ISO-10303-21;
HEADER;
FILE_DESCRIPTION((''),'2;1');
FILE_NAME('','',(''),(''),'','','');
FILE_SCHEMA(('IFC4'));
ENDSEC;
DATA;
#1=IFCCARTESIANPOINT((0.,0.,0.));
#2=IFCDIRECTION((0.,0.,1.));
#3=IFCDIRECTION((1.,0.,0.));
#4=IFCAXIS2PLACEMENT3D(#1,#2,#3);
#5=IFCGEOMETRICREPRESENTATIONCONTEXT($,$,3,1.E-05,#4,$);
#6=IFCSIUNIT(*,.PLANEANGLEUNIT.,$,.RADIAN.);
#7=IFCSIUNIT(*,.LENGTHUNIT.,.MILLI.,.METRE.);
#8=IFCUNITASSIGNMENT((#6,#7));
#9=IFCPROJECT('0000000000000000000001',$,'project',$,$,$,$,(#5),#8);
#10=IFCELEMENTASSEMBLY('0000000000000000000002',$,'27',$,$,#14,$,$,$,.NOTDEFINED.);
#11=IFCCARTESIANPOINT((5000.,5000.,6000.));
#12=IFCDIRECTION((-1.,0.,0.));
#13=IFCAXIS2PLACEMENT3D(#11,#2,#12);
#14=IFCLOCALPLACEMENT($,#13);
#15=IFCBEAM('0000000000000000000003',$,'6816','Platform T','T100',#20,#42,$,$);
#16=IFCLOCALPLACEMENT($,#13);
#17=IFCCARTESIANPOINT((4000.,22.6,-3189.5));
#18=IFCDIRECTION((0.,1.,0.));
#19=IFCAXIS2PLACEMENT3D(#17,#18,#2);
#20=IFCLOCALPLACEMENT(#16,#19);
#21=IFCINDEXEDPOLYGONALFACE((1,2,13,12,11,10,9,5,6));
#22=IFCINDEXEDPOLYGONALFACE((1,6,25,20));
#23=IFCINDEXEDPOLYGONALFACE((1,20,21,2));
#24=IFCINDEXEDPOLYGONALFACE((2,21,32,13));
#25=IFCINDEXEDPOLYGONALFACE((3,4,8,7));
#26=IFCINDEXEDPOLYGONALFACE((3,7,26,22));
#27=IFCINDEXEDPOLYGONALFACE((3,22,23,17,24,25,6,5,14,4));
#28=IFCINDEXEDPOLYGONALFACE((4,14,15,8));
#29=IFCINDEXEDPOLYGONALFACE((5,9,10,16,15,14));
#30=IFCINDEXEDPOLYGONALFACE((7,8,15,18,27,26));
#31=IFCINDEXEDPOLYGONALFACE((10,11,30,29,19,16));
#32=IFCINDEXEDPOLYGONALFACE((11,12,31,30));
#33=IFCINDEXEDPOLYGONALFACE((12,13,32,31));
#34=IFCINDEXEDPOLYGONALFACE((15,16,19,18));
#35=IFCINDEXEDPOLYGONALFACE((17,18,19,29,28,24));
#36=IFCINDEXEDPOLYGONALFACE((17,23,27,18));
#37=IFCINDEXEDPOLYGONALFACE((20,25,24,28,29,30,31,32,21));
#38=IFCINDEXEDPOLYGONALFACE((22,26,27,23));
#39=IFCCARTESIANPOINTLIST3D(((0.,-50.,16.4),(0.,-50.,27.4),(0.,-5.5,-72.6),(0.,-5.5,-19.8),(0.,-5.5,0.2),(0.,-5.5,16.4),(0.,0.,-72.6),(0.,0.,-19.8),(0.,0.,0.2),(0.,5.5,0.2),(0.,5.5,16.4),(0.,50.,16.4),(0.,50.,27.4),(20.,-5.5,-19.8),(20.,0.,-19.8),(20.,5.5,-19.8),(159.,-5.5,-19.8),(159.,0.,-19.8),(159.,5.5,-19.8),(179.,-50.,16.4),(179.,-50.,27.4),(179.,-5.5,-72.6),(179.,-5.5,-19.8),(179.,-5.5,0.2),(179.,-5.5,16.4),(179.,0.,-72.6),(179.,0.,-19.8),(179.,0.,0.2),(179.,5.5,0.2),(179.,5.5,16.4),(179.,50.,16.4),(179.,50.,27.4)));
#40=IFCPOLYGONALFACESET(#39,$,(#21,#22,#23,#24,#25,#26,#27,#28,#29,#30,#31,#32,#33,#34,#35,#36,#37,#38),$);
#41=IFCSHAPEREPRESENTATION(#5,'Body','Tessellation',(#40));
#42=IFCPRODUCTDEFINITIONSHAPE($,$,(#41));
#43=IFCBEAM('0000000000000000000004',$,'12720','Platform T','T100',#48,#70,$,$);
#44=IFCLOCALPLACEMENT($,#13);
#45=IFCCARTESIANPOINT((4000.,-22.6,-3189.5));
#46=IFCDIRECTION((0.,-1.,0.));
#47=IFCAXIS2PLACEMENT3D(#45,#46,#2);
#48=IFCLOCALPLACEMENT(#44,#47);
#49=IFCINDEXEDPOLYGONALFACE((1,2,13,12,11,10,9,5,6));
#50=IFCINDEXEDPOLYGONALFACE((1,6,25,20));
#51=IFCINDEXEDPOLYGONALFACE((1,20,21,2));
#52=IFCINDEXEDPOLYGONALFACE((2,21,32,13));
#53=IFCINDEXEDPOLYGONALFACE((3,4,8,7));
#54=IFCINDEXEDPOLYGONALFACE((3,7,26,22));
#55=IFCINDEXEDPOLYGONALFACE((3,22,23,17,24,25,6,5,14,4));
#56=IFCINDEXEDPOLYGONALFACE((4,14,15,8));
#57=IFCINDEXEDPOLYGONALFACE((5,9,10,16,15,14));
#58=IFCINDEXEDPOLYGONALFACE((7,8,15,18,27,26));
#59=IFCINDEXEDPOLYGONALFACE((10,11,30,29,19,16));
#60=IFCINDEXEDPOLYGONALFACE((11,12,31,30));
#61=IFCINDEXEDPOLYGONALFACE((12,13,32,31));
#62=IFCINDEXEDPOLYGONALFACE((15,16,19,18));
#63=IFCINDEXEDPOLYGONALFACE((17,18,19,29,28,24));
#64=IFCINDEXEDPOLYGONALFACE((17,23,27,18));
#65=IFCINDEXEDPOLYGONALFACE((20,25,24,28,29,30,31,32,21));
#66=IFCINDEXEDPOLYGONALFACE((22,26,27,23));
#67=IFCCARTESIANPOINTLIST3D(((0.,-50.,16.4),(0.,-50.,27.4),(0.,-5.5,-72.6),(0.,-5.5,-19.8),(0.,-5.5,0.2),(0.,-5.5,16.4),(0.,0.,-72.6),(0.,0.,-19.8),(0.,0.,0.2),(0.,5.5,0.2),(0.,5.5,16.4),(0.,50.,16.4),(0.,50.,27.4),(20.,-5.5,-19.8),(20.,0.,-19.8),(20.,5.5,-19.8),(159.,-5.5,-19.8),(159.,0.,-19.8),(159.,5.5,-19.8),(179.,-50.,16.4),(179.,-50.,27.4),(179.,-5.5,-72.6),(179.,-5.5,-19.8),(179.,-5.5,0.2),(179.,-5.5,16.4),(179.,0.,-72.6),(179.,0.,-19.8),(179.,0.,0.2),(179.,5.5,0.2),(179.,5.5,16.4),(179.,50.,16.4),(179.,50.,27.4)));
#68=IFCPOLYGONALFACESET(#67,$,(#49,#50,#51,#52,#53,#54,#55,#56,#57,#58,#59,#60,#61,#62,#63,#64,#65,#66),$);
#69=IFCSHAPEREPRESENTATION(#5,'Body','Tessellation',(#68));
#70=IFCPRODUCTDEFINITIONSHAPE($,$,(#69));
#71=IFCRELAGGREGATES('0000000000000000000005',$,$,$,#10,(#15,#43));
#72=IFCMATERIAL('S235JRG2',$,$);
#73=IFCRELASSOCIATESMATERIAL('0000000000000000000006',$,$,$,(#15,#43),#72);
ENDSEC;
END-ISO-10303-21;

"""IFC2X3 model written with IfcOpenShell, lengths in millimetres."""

from ifc_helpers import new_model, si_unit, point, frame, origin_with_axes, place, context, project, polyline, line_curve, trimmed, segment, composite_curve, outline, extrude, material, element, aggregate, save


model = new_model("IFC2X3")

# Units and contexts
context_of_model = context(None, 3, precision=1e-05, world=origin_with_axes())
ifc_project = project(units=[si_unit("PLANEANGLEUNIT", "RADIAN"), si_unit("LENGTHUNIT", "METRE", prefix="MILLI")], contexts=[context_of_model])

# Element assembly, beams, openings
assembly_1_placement = place(None, frame((5000.0, 5000.0, 6000.0), z_axis=(0.0, 0.0, 1.0), x_axis=(-1.0, 0.0, 0.0)))
assembly_1 = element("IfcElementAssembly", 1, at=assembly_1_placement, Name="27", PredefinedType="NOTDEFINED")
ifc_material = material(Name="S235JRG2")
placement_1 = place(None, frame((5000.0, 5000.0, 6000.0), z_axis=(0.0, 0.0, 1.0), x_axis=(-1.0, 0.0, 0.0)))
beam_1_placement = place(placement_1, frame((4000.0, 22.6, -3189.5), z_axis=(0.0, 1.0, 0.0), x_axis=(0.0, 0.0, 1.0)))
beam_1 = element("IfcBeam", 2, at=beam_1_placement, material=ifc_material, Name="6816", Description="Platform T", ObjectType="T100", context=context_of_model, shape_type="SweptSolid", body=[
    extrude(outline(polyline([(5.5, -72.6), (5.5, 16.4), (50.0, 16.4), (50.0, 27.4), (-50.0, 27.4), (-50.0, 16.4), (-5.5, 16.4), (-5.5, -72.6), (5.5, -72.6), (5.5, -72.6)])), frame((0.0, 0.0, 0.0), z_axis=(1.0, 0.0, 0.0), x_axis=(0.0, 1.0, 0.0)), (0.0, 0.0, 1.0), 179.0),
])
opening_1_placement = place(beam_1_placement, frame((179.0, 0.0, -72.6), z_axis=(0.0, 1.0, 0.0), x_axis=(0.0, 0.0, 1.0)))
element("IfcOpeningElement", 3, at=opening_1_placement, cuts=beam_1, ObjectType="Recess", context=context_of_model, shape_type="SweptSolid", body=[
    extrude(outline(composite_curve([segment(trimmed(line_curve((0.0, 0.0), (0.0, -1.0, 0.0), 179.0), [point((0.0, 0.0))], [point((0.0, -179.0))], True, "CARTESIAN"), True, "CONTINUOUS"), segment(trimmed(line_curve((0.0, -179.0), (1.0, 0.0, 0.0), 52.8), [point((0.0, -179.0))], [point((52.8, -179.0))], True, "CARTESIAN"), True, "CONTINUOUS"), segment(trimmed(line_curve((52.8, -179.0), (0.0, 1.0, 0.0), 179.0), [point((52.8, -179.0))], [point((52.8, 0.0))], True, "CARTESIAN"), True, "CONTINUOUS"), segment(trimmed(line_curve((52.8, 0.0), (-1.0, 0.0, 0.0), 52.8), [point((52.8, 0.0))], [point((0.0, 0.0))], True, "CARTESIAN"), True, "CONTINUOUS")], self_intersect=False)), origin_with_axes(), (0.0, 0.0, 1.0), 100.0),
])
opening_2_placement = place(beam_1_placement, frame((179.0, 0.0, -19.8), z_axis=(0.0, 1.0, 0.0), x_axis=(0.0, 0.0, 1.0)))
element("IfcOpeningElement", 4, at=opening_2_placement, cuts=beam_1, context=context_of_model, shape_type="SweptSolid", body=[
    extrude(outline(composite_curve([segment(trimmed(line_curve((0.0, 0.0), (1.0, 0.0, 0.0), 20.0), [point((0.0, 0.0))], [point((20.0, 0.0))], True, "CARTESIAN"), True, "CONTINUOUS"), segment(trimmed(line_curve((20.0, 0.0), (-0.707107, -0.707107, 0.0), 28.284271), [point((20.0, 0.0))], [point((0.0, -20.0))], True, "CARTESIAN"), True, "CONTINUOUS"), segment(trimmed(line_curve((0.0, -20.0), (0.0, 1.0, 0.0), 20.0), [point((0.0, -20.0))], [point((0.0, 0.0))], True, "CARTESIAN"), True, "CONTINUOUS")], self_intersect=False)), origin_with_axes(), (0.0, 0.0, 1.0), 100.0),
])
opening_3_placement = place(beam_1_placement, frame((179.0, 0.0, -19.8), z_axis=(0.0, -1.0, 0.0), x_axis=(0.0, 0.0, -1.0)))
element("IfcOpeningElement", 5, at=opening_3_placement, cuts=beam_1, context=context_of_model, shape_type="SweptSolid", body=[
    extrude(outline(composite_curve([segment(trimmed(line_curve((0.0, 0.0), (-1.0, 0.0, 0.0), 20.0), [point((0.0, 0.0))], [point((-20.0, 0.0))], True, "CARTESIAN"), True, "CONTINUOUS"), segment(trimmed(line_curve((-20.0, 0.0), (0.707107, -0.707107, 0.0), 28.284271), [point((-20.0, 0.0))], [point((0.0, -20.0))], True, "CARTESIAN"), True, "CONTINUOUS"), segment(trimmed(line_curve((0.0, -20.0), (0.0, 1.0, 0.0), 20.0), [point((0.0, -20.0))], [point((0.0, 0.0))], True, "CARTESIAN"), True, "CONTINUOUS")], self_intersect=False)), origin_with_axes(), (0.0, 0.0, 1.0), 100.0),
])
opening_4_placement = place(beam_1_placement, frame((0.0, 0.0, -19.8), z_axis=(0.0, -1.0, 0.0), x_axis=(0.0, 0.0, -1.0)))
element("IfcOpeningElement", 6, at=opening_4_placement, cuts=beam_1, context=context_of_model, shape_type="SweptSolid", body=[
    extrude(outline(composite_curve([segment(trimmed(line_curve((0.0, 0.0), (-1.0, 0.0, 0.0), 20.0), [point((0.0, 0.0))], [point((-20.0, 0.0))], True, "CARTESIAN"), True, "CONTINUOUS"), segment(trimmed(line_curve((-20.0, 0.0), (0.707107, 0.707107, 0.0), 28.284271), [point((-20.0, 0.0))], [point((0.0, 20.0))], True, "CARTESIAN"), True, "CONTINUOUS"), segment(trimmed(line_curve((0.0, 20.0), (0.0, -1.0, 0.0), 20.0), [point((0.0, 20.0))], [point((0.0, 0.0))], True, "CARTESIAN"), True, "CONTINUOUS")], self_intersect=False)), origin_with_axes(), (0.0, 0.0, 1.0), 100.0),
])
opening_5_placement = place(beam_1_placement, frame((0.0, 0.0, -19.8), z_axis=(0.0, 1.0, 0.0), x_axis=(0.0, 0.0, 1.0)))
element("IfcOpeningElement", 7, at=opening_5_placement, cuts=beam_1, context=context_of_model, shape_type="SweptSolid", body=[
    extrude(outline(composite_curve([segment(trimmed(line_curve((0.0, 0.0), (1.0, 0.0, 0.0), 20.0), [point((0.0, 0.0))], [point((20.0, 0.0))], True, "CARTESIAN"), True, "CONTINUOUS"), segment(trimmed(line_curve((20.0, 0.0), (-0.707107, 0.707107, 0.0), 28.284271), [point((20.0, 0.0))], [point((0.0, 20.0))], True, "CARTESIAN"), True, "CONTINUOUS"), segment(trimmed(line_curve((0.0, 20.0), (0.0, -1.0, 0.0), 20.0), [point((0.0, 20.0))], [point((0.0, 0.0))], True, "CARTESIAN"), True, "CONTINUOUS")], self_intersect=False)), origin_with_axes(), (0.0, 0.0, 1.0), 100.0),
])
placement_2 = place(None, frame((5000.0, 5000.0, 6000.0), z_axis=(0.0, 0.0, 1.0), x_axis=(-1.0, 0.0, 0.0)))
beam_2_placement = place(placement_2, frame((4000.0, -22.6, -3189.5), z_axis=(0.0, -1.0, 0.0), x_axis=(0.0, 0.0, 1.0)))
beam_2 = element("IfcBeam", 8, at=beam_2_placement, material=ifc_material, Name="12720", Description="Platform T", ObjectType="T100", context=context_of_model, shape_type="SweptSolid", body=[
    extrude(outline(polyline([(5.5, -72.6), (5.5, 16.4), (50.0, 16.4), (50.0, 27.4), (-50.0, 27.4), (-50.0, 16.4), (-5.5, 16.4), (-5.5, -72.6), (5.5, -72.6), (5.5, -72.6)])), frame((0.0, 0.0, 0.0), z_axis=(1.0, 0.0, 0.0), x_axis=(0.0, 1.0, 0.0)), (0.0, 0.0, 1.0), 179.0),
])
opening_6_placement = place(beam_2_placement, frame((179.0, 0.0, -72.6), z_axis=(0.0, 1.0, 0.0), x_axis=(0.0, 0.0, 1.0)))
element("IfcOpeningElement", 9, at=opening_6_placement, cuts=beam_2, ObjectType="Recess", context=context_of_model, shape_type="SweptSolid", body=[
    extrude(outline(composite_curve([segment(trimmed(line_curve((0.0, 0.0), (0.0, -1.0, 0.0), 179.0), [point((0.0, 0.0))], [point((0.0, -179.0))], True, "CARTESIAN"), True, "CONTINUOUS"), segment(trimmed(line_curve((0.0, -179.0), (1.0, 0.0, 0.0), 52.8), [point((0.0, -179.0))], [point((52.8, -179.0))], True, "CARTESIAN"), True, "CONTINUOUS"), segment(trimmed(line_curve((52.8, -179.0), (0.0, 1.0, 0.0), 179.0), [point((52.8, -179.0))], [point((52.8, 0.0))], True, "CARTESIAN"), True, "CONTINUOUS"), segment(trimmed(line_curve((52.8, 0.0), (-1.0, 0.0, 0.0), 52.8), [point((52.8, 0.0))], [point((0.0, 0.0))], True, "CARTESIAN"), True, "CONTINUOUS")], self_intersect=False)), origin_with_axes(), (0.0, 0.0, 1.0), 100.0),
])
opening_7_placement = place(beam_2_placement, frame((179.0, 0.0, -19.8), z_axis=(0.0, 1.0, 0.0), x_axis=(0.0, 0.0, 1.0)))
element("IfcOpeningElement", 10, at=opening_7_placement, cuts=beam_2, context=context_of_model, shape_type="SweptSolid", body=[
    extrude(outline(composite_curve([segment(trimmed(line_curve((0.0, 0.0), (1.0, 0.0, 0.0), 20.0), [point((0.0, 0.0))], [point((20.0, 0.0))], True, "CARTESIAN"), True, "CONTINUOUS"), segment(trimmed(line_curve((20.0, 0.0), (-0.707107, -0.707107, 0.0), 28.284271), [point((20.0, 0.0))], [point((0.0, -20.0))], True, "CARTESIAN"), True, "CONTINUOUS"), segment(trimmed(line_curve((0.0, -20.0), (0.0, 1.0, 0.0), 20.0), [point((0.0, -20.0))], [point((0.0, 0.0))], True, "CARTESIAN"), True, "CONTINUOUS")], self_intersect=False)), origin_with_axes(), (0.0, 0.0, 1.0), 100.0),
])
opening_8_placement = place(beam_2_placement, frame((179.0, 0.0, -19.8), z_axis=(0.0, -1.0, 0.0), x_axis=(0.0, 0.0, -1.0)))
element("IfcOpeningElement", 11, at=opening_8_placement, cuts=beam_2, context=context_of_model, shape_type="SweptSolid", body=[
    extrude(outline(composite_curve([segment(trimmed(line_curve((0.0, 0.0), (-1.0, 0.0, 0.0), 20.0), [point((0.0, 0.0))], [point((-20.0, 0.0))], True, "CARTESIAN"), True, "CONTINUOUS"), segment(trimmed(line_curve((-20.0, 0.0), (0.707107, -0.707107, 0.0), 28.284271), [point((-20.0, 0.0))], [point((0.0, -20.0))], True, "CARTESIAN"), True, "CONTINUOUS"), segment(trimmed(line_curve((0.0, -20.0), (0.0, 1.0, 0.0), 20.0), [point((0.0, -20.0))], [point((0.0, 0.0))], True, "CARTESIAN"), True, "CONTINUOUS")], self_intersect=False)), origin_with_axes(), (0.0, 0.0, 1.0), 100.0),
])
opening_9_placement = place(beam_2_placement, frame((0.0, 0.0, -19.8), z_axis=(0.0, -1.0, 0.0), x_axis=(0.0, 0.0, -1.0)))
element("IfcOpeningElement", 12, at=opening_9_placement, cuts=beam_2, context=context_of_model, shape_type="SweptSolid", body=[
    extrude(outline(composite_curve([segment(trimmed(line_curve((0.0, 0.0), (-1.0, 0.0, 0.0), 20.0), [point((0.0, 0.0))], [point((-20.0, 0.0))], True, "CARTESIAN"), True, "CONTINUOUS"), segment(trimmed(line_curve((-20.0, 0.0), (0.707107, 0.707107, 0.0), 28.284271), [point((-20.0, 0.0))], [point((0.0, 20.0))], True, "CARTESIAN"), True, "CONTINUOUS"), segment(trimmed(line_curve((0.0, 20.0), (0.0, -1.0, 0.0), 20.0), [point((0.0, 20.0))], [point((0.0, 0.0))], True, "CARTESIAN"), True, "CONTINUOUS")], self_intersect=False)), origin_with_axes(), (0.0, 0.0, 1.0), 100.0),
])
opening_10_placement = place(beam_2_placement, frame((0.0, 0.0, -19.8), z_axis=(0.0, 1.0, 0.0), x_axis=(0.0, 0.0, 1.0)))
element("IfcOpeningElement", 13, at=opening_10_placement, cuts=beam_2, context=context_of_model, shape_type="SweptSolid", body=[
    extrude(outline(composite_curve([segment(trimmed(line_curve((0.0, 0.0), (1.0, 0.0, 0.0), 20.0), [point((0.0, 0.0))], [point((20.0, 0.0))], True, "CARTESIAN"), True, "CONTINUOUS"), segment(trimmed(line_curve((20.0, 0.0), (-0.707107, 0.707107, 0.0), 28.284271), [point((20.0, 0.0))], [point((0.0, 20.0))], True, "CARTESIAN"), True, "CONTINUOUS"), segment(trimmed(line_curve((0.0, 20.0), (0.0, -1.0, 0.0), 20.0), [point((0.0, 20.0))], [point((0.0, 0.0))], True, "CARTESIAN"), True, "CONTINUOUS")], self_intersect=False)), origin_with_axes(), (0.0, 0.0, 1.0), 100.0),
])
aggregate(assembly_1, [beam_1, beam_2])

save(model, "model.ifc")
